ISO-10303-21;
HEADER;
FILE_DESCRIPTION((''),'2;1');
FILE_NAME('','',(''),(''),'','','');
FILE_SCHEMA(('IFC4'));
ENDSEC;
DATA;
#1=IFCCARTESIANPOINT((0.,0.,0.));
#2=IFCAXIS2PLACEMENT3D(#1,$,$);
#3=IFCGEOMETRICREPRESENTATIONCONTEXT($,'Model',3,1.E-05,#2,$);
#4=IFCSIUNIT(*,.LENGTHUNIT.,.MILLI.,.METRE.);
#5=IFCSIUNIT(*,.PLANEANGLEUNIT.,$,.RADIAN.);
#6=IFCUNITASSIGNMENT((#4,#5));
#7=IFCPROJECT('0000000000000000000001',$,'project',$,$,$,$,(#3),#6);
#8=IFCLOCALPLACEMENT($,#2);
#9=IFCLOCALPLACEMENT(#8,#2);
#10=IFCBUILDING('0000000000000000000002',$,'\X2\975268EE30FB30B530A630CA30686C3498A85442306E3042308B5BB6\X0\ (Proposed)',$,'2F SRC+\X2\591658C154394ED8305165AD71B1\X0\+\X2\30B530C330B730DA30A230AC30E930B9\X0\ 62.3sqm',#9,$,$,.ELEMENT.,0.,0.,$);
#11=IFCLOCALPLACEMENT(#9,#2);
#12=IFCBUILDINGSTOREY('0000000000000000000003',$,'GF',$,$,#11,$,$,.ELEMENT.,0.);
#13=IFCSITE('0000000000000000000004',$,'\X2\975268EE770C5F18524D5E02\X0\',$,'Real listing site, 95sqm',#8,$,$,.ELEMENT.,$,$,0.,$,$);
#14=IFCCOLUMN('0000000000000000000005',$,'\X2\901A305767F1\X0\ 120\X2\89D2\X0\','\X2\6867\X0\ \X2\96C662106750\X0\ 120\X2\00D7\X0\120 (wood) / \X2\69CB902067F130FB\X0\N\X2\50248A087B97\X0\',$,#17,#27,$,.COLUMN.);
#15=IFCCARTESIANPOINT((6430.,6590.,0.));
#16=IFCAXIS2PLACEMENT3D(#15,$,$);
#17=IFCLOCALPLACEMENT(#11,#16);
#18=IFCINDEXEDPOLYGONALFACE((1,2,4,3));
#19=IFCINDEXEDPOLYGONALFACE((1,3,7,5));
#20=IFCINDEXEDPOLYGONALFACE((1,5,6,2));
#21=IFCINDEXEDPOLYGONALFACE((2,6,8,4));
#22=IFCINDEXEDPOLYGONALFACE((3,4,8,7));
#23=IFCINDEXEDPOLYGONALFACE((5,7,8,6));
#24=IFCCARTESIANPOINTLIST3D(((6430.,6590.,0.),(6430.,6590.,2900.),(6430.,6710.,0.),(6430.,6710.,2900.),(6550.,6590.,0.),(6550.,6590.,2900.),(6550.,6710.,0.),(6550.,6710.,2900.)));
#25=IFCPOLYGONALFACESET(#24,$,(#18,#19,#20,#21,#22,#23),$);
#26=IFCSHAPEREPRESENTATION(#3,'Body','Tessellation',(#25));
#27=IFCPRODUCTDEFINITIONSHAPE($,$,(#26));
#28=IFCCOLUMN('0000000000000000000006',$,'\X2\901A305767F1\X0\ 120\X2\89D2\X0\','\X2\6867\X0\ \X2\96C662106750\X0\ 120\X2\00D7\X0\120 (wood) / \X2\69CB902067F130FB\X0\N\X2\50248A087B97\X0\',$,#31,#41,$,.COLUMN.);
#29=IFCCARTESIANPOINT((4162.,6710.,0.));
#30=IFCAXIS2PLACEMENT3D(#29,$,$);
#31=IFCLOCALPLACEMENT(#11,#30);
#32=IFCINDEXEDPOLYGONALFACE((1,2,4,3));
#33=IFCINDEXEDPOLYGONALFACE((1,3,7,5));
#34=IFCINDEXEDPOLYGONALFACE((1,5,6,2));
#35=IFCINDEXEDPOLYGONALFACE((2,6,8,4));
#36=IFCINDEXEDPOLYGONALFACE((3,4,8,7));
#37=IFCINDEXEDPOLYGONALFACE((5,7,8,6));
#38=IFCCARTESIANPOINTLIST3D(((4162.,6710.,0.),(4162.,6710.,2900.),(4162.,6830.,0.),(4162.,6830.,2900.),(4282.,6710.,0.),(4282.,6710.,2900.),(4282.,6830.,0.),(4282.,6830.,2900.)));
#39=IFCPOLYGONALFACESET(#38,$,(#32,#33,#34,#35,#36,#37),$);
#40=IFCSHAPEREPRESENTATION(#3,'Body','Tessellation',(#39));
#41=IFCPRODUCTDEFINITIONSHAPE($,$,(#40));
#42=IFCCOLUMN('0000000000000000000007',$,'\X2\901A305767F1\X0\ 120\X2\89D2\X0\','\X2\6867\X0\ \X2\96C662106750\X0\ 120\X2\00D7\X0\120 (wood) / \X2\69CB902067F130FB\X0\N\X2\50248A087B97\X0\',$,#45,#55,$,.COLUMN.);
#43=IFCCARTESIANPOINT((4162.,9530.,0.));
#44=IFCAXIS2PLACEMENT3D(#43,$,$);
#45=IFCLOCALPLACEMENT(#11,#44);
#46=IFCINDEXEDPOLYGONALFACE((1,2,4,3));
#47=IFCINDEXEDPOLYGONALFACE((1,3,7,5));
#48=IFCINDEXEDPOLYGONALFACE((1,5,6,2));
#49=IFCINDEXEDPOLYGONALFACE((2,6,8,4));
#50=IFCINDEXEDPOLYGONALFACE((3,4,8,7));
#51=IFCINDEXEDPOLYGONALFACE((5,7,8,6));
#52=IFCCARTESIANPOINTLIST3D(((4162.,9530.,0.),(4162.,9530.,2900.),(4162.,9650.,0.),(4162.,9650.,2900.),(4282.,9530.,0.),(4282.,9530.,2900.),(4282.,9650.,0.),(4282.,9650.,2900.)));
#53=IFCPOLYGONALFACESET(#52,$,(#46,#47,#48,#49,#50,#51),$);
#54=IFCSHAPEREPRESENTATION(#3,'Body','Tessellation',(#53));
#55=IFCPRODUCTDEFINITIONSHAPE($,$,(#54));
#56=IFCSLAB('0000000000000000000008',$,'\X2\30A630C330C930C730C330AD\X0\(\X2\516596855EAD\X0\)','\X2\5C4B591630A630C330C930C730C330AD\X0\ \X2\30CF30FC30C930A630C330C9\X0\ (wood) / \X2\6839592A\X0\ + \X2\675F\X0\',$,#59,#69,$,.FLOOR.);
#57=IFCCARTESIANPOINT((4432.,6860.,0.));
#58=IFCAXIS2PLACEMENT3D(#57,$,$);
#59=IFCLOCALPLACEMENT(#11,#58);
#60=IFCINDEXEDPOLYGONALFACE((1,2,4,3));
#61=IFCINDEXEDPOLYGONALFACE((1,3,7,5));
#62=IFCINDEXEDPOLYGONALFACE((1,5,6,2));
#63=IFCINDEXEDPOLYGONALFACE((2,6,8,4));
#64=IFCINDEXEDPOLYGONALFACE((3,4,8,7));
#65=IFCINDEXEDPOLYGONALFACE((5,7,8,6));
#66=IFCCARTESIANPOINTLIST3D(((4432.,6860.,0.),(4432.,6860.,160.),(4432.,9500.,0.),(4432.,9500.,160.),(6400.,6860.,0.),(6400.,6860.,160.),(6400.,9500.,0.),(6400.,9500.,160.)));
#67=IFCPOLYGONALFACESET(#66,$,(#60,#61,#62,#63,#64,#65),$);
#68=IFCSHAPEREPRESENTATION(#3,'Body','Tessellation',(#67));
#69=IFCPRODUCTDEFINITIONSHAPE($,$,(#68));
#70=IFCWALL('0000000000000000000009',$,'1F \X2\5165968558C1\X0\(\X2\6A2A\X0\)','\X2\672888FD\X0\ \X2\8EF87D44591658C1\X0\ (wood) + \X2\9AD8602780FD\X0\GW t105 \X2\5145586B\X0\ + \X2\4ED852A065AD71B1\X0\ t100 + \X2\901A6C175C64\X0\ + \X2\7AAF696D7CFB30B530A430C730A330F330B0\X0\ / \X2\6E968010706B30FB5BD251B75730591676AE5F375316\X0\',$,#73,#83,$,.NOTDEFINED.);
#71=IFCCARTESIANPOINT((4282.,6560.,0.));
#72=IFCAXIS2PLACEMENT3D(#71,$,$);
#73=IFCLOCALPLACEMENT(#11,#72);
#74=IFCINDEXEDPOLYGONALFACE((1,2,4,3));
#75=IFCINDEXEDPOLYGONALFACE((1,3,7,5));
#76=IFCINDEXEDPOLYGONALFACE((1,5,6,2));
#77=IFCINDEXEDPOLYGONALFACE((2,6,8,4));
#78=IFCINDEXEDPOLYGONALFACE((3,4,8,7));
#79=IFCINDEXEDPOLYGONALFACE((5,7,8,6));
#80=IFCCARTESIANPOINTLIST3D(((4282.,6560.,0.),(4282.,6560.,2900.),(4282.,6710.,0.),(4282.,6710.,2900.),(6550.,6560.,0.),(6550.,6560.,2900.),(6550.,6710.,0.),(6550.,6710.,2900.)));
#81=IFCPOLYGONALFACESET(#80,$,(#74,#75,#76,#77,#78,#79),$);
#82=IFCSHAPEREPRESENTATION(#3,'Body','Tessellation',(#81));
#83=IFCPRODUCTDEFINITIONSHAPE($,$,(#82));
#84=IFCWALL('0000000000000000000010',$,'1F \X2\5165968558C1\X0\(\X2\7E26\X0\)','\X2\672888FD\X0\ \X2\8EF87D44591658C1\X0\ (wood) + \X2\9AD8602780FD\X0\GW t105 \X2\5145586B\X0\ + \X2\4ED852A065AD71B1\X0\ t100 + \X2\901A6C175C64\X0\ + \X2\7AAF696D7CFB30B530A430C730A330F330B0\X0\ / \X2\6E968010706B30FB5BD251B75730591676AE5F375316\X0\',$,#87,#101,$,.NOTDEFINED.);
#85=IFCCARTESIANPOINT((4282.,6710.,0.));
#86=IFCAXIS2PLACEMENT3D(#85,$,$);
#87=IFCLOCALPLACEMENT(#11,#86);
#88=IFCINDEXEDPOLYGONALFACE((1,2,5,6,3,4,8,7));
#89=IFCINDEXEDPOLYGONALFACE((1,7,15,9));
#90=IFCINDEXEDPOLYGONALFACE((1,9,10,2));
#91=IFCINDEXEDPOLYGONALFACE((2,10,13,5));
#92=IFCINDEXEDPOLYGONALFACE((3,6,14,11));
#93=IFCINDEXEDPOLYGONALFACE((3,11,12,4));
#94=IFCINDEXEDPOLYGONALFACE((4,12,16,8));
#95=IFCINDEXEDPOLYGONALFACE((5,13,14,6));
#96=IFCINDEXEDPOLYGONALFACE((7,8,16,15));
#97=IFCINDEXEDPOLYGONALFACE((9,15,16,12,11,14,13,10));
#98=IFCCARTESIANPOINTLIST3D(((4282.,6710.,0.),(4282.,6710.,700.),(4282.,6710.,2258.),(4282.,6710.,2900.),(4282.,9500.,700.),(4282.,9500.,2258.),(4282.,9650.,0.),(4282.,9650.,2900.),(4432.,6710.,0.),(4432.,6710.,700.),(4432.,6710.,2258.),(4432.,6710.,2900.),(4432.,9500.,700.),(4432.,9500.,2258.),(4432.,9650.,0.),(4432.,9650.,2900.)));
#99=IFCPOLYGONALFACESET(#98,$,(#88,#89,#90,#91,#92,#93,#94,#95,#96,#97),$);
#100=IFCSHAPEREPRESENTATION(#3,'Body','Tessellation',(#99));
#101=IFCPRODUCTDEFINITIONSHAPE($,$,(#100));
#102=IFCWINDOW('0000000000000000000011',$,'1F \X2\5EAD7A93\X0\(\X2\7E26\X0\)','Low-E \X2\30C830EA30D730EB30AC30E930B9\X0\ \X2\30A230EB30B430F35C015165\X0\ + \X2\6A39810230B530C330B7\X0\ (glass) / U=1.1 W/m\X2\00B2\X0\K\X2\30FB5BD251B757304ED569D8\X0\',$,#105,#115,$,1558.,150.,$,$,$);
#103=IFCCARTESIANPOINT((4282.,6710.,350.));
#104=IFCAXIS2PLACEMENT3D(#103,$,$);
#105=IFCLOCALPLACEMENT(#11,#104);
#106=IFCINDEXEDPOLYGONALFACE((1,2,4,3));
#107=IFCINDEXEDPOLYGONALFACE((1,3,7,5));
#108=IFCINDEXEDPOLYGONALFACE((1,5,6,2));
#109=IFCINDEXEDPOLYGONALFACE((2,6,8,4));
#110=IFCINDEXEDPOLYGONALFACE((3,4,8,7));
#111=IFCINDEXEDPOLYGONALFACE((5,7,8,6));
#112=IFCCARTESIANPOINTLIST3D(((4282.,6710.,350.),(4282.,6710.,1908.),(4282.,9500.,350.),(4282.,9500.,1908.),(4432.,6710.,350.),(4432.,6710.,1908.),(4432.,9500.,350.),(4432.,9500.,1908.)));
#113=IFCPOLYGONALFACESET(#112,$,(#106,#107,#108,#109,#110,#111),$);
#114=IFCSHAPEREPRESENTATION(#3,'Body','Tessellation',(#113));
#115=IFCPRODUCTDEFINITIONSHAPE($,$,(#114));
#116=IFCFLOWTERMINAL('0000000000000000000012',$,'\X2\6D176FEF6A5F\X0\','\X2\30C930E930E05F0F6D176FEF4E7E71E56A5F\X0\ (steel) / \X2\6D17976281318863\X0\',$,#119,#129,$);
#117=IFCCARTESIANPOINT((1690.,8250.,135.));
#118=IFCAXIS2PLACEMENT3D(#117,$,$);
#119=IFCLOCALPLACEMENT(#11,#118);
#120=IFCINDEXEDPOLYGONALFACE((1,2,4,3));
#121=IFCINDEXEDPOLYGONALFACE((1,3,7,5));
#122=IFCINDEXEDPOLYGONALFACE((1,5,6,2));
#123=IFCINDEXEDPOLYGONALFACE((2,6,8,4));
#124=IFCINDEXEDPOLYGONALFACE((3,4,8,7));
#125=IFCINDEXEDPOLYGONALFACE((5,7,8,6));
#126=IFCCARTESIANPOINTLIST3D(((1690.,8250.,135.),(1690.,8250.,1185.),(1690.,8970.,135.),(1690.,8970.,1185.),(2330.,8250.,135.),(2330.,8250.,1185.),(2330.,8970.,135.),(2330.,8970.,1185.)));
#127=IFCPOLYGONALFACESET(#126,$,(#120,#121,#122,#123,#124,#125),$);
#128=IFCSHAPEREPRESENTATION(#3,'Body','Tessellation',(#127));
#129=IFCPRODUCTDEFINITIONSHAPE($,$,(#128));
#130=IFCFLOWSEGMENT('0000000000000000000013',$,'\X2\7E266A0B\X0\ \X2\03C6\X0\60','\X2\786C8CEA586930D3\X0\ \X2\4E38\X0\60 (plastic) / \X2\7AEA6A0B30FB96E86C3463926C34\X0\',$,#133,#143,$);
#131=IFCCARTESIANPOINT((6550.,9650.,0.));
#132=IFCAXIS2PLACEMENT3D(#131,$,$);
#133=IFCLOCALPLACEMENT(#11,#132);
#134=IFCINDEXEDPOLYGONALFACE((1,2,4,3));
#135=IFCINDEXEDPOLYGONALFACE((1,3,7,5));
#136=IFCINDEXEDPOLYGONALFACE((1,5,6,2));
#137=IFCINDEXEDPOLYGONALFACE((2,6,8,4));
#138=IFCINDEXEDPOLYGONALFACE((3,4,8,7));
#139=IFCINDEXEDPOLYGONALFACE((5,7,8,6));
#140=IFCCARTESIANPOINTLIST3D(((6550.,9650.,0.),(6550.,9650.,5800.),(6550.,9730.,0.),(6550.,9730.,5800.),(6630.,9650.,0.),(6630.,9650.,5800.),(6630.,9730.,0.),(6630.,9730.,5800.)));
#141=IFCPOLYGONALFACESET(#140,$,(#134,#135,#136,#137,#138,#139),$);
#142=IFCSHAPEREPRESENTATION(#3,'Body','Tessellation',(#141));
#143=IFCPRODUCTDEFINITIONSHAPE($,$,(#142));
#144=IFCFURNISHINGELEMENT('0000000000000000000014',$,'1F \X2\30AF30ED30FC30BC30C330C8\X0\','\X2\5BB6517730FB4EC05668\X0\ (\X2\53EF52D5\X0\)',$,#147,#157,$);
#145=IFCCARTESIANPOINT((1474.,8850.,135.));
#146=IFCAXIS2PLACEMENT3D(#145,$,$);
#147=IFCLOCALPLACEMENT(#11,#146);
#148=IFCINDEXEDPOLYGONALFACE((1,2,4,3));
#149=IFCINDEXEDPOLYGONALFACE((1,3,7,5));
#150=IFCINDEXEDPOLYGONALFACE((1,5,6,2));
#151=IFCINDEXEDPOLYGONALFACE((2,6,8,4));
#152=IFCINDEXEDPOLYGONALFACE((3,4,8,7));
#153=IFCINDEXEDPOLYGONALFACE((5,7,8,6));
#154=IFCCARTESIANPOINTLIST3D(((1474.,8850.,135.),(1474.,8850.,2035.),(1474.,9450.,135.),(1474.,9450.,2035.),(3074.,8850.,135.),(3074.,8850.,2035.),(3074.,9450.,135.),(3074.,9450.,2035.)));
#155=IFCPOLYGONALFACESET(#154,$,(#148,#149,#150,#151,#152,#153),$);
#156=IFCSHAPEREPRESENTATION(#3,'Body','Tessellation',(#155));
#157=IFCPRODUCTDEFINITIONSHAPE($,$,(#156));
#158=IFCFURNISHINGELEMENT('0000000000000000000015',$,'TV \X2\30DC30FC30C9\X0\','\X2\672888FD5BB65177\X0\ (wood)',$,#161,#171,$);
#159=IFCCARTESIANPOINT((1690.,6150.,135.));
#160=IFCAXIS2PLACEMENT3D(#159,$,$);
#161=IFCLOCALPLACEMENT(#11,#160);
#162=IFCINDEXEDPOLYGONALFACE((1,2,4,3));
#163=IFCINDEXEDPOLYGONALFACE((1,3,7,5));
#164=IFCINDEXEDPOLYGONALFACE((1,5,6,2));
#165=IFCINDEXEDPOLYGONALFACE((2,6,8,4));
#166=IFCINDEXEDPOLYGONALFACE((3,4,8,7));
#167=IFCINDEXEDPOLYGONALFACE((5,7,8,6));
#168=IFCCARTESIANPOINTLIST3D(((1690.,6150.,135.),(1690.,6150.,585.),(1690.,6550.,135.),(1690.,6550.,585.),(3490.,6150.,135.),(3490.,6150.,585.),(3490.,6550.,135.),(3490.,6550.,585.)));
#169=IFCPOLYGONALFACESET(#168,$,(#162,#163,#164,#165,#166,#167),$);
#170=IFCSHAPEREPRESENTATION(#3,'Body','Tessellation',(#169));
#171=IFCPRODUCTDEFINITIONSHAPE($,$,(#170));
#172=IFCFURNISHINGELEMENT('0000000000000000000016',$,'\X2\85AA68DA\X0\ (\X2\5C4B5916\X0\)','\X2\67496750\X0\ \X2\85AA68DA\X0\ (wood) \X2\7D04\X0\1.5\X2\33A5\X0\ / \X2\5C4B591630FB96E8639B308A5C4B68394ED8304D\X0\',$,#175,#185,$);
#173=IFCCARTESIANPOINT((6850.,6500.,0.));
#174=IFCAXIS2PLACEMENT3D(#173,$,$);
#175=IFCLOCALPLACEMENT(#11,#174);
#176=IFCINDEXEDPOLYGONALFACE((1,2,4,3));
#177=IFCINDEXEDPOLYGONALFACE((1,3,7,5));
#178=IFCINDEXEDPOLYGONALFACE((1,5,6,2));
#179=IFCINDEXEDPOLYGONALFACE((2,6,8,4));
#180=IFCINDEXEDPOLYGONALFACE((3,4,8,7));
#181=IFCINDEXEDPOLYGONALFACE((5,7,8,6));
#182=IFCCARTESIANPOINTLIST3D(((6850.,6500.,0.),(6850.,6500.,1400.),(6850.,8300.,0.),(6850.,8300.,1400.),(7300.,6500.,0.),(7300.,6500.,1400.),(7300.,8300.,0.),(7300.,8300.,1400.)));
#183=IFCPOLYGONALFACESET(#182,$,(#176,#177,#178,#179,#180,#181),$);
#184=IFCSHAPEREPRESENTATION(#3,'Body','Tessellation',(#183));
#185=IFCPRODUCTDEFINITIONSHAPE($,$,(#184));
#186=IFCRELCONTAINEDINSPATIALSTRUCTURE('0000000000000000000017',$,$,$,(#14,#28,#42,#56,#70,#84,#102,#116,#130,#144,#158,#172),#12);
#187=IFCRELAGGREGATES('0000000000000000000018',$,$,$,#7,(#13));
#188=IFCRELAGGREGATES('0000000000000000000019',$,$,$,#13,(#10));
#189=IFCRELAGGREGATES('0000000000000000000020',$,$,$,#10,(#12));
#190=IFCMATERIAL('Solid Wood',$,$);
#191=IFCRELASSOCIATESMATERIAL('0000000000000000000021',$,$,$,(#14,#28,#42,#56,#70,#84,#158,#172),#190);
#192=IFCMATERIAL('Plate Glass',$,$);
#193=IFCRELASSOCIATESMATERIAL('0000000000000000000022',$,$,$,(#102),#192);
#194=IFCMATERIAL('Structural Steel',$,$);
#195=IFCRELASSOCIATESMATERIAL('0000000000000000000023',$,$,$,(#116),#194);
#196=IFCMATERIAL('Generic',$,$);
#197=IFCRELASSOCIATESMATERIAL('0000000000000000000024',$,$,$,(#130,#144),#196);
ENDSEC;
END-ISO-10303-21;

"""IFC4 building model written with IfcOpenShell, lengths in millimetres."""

from ifc_helpers import new_model, si_unit, frame, frame_2d, origin, place, context, project, spatial, rectangle, extrude, material, element, fill, save


model = new_model("IFC4")

# Units and contexts
model_context = context("Model", 3, precision=1e-05, world=origin())
ifc_project = project(units=[si_unit("LENGTHUNIT", "METRE", prefix="MILLI"), si_unit("PLANEANGLEUNIT", "RADIAN")], contexts=[model_context])

# Site, building, storey
site_placement = place(None, origin())
site = spatial("IfcSite", under=ifc_project, at=site_placement, Name="青森県弘前市", ObjectType="Real listing site, 95sqm", CompositionType="ELEMENT", RefElevation=0.0)
building_placement = place(site_placement, origin())
building = spatial("IfcBuilding", under=site, at=building_placement, Name="青森・サウナと水風呂のある家 (Proposed)", ObjectType="2F SRC+外壁吹付け断熱+サッシペアガラス 62.3sqm", CompositionType="ELEMENT", ElevationOfRefHeight=0.0, ElevationOfTerrain=0.0)
storey_placement = place(building_placement, origin())
storey = spatial("IfcBuildingStorey", under=building, at=storey_placement, Name="GF", CompositionType="ELEMENT", Elevation=0.0)

# Columns
ifc_material_1 = material(Name="Solid Wood")
column_1_placement = place(storey_placement, frame((6430.0, 6590.0, 0.0)))
element("IfcColumn", 1, at=column_1_placement, inside=storey, material=ifc_material_1, Name="通し柱 120角", Description="桧 集成材 120×120 (wood) / 構造柱・N値計算", PredefinedType="COLUMN", context=model_context, shape_type="SweptSolid", body=[
    extrude(rectangle(XDim=120.0, YDim=120.0, at=frame_2d((60.0, 60.0))), frame((6430.0, 6590.0, 0.0)), (0.0, 0.0, 1.0), 2900.0),
])
column_2_placement = place(storey_placement, frame((4162.0, 6710.0, 0.0)))
element("IfcColumn", 2, at=column_2_placement, inside=storey, material=ifc_material_1, Name="通し柱 120角", Description="桧 集成材 120×120 (wood) / 構造柱・N値計算", PredefinedType="COLUMN", context=model_context, shape_type="SweptSolid", body=[
    extrude(rectangle(XDim=120.0, YDim=120.0, at=frame_2d((60.0, 60.0))), frame((4162.0, 6710.0, 0.0)), (0.0, 0.0, 1.0), 2900.0),
])
column_3_placement = place(storey_placement, frame((4162.0, 9530.0, 0.0)))
element("IfcColumn", 3, at=column_3_placement, inside=storey, material=ifc_material_1, Name="通し柱 120角", Description="桧 集成材 120×120 (wood) / 構造柱・N値計算", PredefinedType="COLUMN", context=model_context, shape_type="SweptSolid", body=[
    extrude(rectangle(XDim=120.0, YDim=120.0, at=frame_2d((60.0, 60.0))), frame((4162.0, 9530.0, 0.0)), (0.0, 0.0, 1.0), 2900.0),
])

# Slab
slab_placement = place(storey_placement, frame((4432.0, 6860.0, 0.0)))
element("IfcSlab", 4, at=slab_placement, inside=storey, material=ifc_material_1, Name="ウッドデッキ(入隅庭)", Description="屋外ウッドデッキ ハードウッド (wood) / 根太 + 束", PredefinedType="FLOOR", context=model_context, shape_type="SweptSolid", body=[
    extrude(rectangle(XDim=1968.0, YDim=2640.0, at=frame_2d((984.0, 1320.0))), frame((4432.0, 6860.0, 0.0)), (0.0, 0.0, 1.0), 160.0),
])

# Wall
wall_1_placement = place(storey_placement, frame((4282.0, 6560.0, 0.0)))
element("IfcWall", 5, at=wall_1_placement, inside=storey, material=ifc_material_1, Name="1F 入隅壁(横)", Description="木製 軸組外壁 (wood) + 高性能GW t105 充填 + 付加断熱 t100 + 通気層 + 窯業系サイディング / 準耐火・寒冷地外皮強化", PredefinedType="NOTDEFINED", context=model_context, shape_type="SweptSolid", body=[
    extrude(rectangle(XDim=2268.0, YDim=150.0, at=frame_2d((1134.0, 75.0))), frame((4282.0, 6560.0, 0.0)), (0.0, 0.0, 1.0), 2900.0),
])

# Wall, opening, window
wall_2_placement = place(storey_placement, frame((4282.0, 6710.0, 0.0)))
wall_2 = element("IfcWall", 6, at=wall_2_placement, inside=storey, material=ifc_material_1, Name="1F 入隅壁(縦)", Description="木製 軸組外壁 (wood) + 高性能GW t105 充填 + 付加断熱 t100 + 通気層 + 窯業系サイディング / 準耐火・寒冷地外皮強化", PredefinedType="NOTDEFINED", context=model_context, shape_type="SweptSolid", body=[
    extrude(rectangle(XDim=150.0, YDim=2940.0, at=frame_2d((75.0, 1470.0))), frame((4282.0, 6710.0, 0.0)), (0.0, 0.0, 1.0), 2900.0),
])
opening_placement = place(storey_placement, frame((4282.0, 6710.0, 350.0)))
opening = element("IfcOpeningElement", 7, at=opening_placement, cuts=wall_2, PredefinedType="NOTDEFINED", context=model_context, shape_type="SweptSolid", body=[
    extrude(rectangle(XDim=150.0, YDim=2790.0, at=frame_2d((75.0, 1395.0))), frame((4282.0, 6710.0, 350.0)), (0.0, 0.0, 1.0), 1558.0),
])
ifc_material_2 = material(Name="Plate Glass")
window_placement = place(storey_placement, frame((4282.0, 6710.0, 350.0)))
window = element("IfcWindow", 8, at=window_placement, inside=storey, material=ifc_material_2, Name="1F 庭窓(縦)", Description="Low-E トリプルガラス アルゴン封入 + 樹脂サッシ (glass) / U=1.1 W/m²K・寒冷地仕様", OverallHeight=1558.0, OverallWidth=150.0, context=model_context, shape_type="SweptSolid", body=[
    extrude(rectangle(XDim=150.0, YDim=2790.0, at=frame_2d((75.0, 1395.0))), frame((4282.0, 6710.0, 350.0)), (0.0, 0.0, 1.0), 1558.0),
])
fill(opening, window)

# Flow terminal
ifc_material_3 = material(Name="Structural Steel")
flow_terminal_placement = place(storey_placement, frame((1690.0, 8250.0, 135.0)))
element("IfcFlowTerminal", 9, at=flow_terminal_placement, inside=storey, material=ifc_material_3, Name="洗濯機", Description="ドラム式洗濯乾燥機 (steel) / 洗面脱衣", context=model_context, shape_type="SweptSolid", body=[
    extrude(rectangle(XDim=640.0, YDim=720.0, at=frame_2d((320.0, 360.0))), frame((1690.0, 8250.0, 135.0)), (0.0, 0.0, 1.0), 1050.0),
])

# Flow segment
ifc_material_4 = material(Name="Generic")
flow_segment_placement = place(storey_placement, frame((6550.0, 9650.0, 0.0)))
element("IfcFlowSegment", 10, at=flow_segment_placement, inside=storey, material=ifc_material_4, Name="縦樋 φ60", Description="硬質塩ビ 丸60 (plastic) / 竪樋・雨水排水", context=model_context, shape_type="SweptSolid", body=[
    extrude(rectangle(XDim=80.0, YDim=80.0, at=frame_2d((40.0, 40.0))), frame((6550.0, 9650.0, 0.0)), (0.0, 0.0, 1.0), 5800.0),
])

# Furnishing elements
furnishing_1_placement = place(storey_placement, frame((1474.0, 8850.0, 135.0)))
element("IfcFurnishingElement", 11, at=furnishing_1_placement, inside=storey, material=ifc_material_4, Name="1F クローゼット", Description="家具・什器 (可動)", context=model_context, shape_type="SweptSolid", body=[
    extrude(rectangle(XDim=1600.0, YDim=600.0, at=frame_2d((800.0, 300.0))), frame((1474.0, 8850.0, 135.0)), (0.0, 0.0, 1.0), 1900.0),
])
furnishing_2_placement = place(storey_placement, frame((1690.0, 6150.0, 135.0)))
element("IfcFurnishingElement", 12, at=furnishing_2_placement, inside=storey, material=ifc_material_1, Name="TV ボード", Description="木製家具 (wood)", context=model_context, shape_type="SweptSolid", body=[
    extrude(rectangle(XDim=1800.0, YDim=400.0, at=frame_2d((900.0, 200.0))), frame((1690.0, 6150.0, 135.0)), (0.0, 0.0, 1.0), 450.0),
])
furnishing_3_placement = place(storey_placement, frame((6850.0, 6500.0, 0.0)))
element("IfcFurnishingElement", 13, at=furnishing_3_placement, inside=storey, material=ifc_material_1, Name="薪棚 (屋外)", Description="杉材 薪棚 (wood) 約1.5㎥ / 屋外・雨掛り屋根付き", context=model_context, shape_type="SweptSolid", body=[
    extrude(rectangle(XDim=450.0, YDim=1800.0, at=frame_2d((225.0, 900.0))), frame((6850.0, 6500.0, 0.0)), (0.0, 0.0, 1.0), 1400.0),
])

save(model, "model.ifc")
